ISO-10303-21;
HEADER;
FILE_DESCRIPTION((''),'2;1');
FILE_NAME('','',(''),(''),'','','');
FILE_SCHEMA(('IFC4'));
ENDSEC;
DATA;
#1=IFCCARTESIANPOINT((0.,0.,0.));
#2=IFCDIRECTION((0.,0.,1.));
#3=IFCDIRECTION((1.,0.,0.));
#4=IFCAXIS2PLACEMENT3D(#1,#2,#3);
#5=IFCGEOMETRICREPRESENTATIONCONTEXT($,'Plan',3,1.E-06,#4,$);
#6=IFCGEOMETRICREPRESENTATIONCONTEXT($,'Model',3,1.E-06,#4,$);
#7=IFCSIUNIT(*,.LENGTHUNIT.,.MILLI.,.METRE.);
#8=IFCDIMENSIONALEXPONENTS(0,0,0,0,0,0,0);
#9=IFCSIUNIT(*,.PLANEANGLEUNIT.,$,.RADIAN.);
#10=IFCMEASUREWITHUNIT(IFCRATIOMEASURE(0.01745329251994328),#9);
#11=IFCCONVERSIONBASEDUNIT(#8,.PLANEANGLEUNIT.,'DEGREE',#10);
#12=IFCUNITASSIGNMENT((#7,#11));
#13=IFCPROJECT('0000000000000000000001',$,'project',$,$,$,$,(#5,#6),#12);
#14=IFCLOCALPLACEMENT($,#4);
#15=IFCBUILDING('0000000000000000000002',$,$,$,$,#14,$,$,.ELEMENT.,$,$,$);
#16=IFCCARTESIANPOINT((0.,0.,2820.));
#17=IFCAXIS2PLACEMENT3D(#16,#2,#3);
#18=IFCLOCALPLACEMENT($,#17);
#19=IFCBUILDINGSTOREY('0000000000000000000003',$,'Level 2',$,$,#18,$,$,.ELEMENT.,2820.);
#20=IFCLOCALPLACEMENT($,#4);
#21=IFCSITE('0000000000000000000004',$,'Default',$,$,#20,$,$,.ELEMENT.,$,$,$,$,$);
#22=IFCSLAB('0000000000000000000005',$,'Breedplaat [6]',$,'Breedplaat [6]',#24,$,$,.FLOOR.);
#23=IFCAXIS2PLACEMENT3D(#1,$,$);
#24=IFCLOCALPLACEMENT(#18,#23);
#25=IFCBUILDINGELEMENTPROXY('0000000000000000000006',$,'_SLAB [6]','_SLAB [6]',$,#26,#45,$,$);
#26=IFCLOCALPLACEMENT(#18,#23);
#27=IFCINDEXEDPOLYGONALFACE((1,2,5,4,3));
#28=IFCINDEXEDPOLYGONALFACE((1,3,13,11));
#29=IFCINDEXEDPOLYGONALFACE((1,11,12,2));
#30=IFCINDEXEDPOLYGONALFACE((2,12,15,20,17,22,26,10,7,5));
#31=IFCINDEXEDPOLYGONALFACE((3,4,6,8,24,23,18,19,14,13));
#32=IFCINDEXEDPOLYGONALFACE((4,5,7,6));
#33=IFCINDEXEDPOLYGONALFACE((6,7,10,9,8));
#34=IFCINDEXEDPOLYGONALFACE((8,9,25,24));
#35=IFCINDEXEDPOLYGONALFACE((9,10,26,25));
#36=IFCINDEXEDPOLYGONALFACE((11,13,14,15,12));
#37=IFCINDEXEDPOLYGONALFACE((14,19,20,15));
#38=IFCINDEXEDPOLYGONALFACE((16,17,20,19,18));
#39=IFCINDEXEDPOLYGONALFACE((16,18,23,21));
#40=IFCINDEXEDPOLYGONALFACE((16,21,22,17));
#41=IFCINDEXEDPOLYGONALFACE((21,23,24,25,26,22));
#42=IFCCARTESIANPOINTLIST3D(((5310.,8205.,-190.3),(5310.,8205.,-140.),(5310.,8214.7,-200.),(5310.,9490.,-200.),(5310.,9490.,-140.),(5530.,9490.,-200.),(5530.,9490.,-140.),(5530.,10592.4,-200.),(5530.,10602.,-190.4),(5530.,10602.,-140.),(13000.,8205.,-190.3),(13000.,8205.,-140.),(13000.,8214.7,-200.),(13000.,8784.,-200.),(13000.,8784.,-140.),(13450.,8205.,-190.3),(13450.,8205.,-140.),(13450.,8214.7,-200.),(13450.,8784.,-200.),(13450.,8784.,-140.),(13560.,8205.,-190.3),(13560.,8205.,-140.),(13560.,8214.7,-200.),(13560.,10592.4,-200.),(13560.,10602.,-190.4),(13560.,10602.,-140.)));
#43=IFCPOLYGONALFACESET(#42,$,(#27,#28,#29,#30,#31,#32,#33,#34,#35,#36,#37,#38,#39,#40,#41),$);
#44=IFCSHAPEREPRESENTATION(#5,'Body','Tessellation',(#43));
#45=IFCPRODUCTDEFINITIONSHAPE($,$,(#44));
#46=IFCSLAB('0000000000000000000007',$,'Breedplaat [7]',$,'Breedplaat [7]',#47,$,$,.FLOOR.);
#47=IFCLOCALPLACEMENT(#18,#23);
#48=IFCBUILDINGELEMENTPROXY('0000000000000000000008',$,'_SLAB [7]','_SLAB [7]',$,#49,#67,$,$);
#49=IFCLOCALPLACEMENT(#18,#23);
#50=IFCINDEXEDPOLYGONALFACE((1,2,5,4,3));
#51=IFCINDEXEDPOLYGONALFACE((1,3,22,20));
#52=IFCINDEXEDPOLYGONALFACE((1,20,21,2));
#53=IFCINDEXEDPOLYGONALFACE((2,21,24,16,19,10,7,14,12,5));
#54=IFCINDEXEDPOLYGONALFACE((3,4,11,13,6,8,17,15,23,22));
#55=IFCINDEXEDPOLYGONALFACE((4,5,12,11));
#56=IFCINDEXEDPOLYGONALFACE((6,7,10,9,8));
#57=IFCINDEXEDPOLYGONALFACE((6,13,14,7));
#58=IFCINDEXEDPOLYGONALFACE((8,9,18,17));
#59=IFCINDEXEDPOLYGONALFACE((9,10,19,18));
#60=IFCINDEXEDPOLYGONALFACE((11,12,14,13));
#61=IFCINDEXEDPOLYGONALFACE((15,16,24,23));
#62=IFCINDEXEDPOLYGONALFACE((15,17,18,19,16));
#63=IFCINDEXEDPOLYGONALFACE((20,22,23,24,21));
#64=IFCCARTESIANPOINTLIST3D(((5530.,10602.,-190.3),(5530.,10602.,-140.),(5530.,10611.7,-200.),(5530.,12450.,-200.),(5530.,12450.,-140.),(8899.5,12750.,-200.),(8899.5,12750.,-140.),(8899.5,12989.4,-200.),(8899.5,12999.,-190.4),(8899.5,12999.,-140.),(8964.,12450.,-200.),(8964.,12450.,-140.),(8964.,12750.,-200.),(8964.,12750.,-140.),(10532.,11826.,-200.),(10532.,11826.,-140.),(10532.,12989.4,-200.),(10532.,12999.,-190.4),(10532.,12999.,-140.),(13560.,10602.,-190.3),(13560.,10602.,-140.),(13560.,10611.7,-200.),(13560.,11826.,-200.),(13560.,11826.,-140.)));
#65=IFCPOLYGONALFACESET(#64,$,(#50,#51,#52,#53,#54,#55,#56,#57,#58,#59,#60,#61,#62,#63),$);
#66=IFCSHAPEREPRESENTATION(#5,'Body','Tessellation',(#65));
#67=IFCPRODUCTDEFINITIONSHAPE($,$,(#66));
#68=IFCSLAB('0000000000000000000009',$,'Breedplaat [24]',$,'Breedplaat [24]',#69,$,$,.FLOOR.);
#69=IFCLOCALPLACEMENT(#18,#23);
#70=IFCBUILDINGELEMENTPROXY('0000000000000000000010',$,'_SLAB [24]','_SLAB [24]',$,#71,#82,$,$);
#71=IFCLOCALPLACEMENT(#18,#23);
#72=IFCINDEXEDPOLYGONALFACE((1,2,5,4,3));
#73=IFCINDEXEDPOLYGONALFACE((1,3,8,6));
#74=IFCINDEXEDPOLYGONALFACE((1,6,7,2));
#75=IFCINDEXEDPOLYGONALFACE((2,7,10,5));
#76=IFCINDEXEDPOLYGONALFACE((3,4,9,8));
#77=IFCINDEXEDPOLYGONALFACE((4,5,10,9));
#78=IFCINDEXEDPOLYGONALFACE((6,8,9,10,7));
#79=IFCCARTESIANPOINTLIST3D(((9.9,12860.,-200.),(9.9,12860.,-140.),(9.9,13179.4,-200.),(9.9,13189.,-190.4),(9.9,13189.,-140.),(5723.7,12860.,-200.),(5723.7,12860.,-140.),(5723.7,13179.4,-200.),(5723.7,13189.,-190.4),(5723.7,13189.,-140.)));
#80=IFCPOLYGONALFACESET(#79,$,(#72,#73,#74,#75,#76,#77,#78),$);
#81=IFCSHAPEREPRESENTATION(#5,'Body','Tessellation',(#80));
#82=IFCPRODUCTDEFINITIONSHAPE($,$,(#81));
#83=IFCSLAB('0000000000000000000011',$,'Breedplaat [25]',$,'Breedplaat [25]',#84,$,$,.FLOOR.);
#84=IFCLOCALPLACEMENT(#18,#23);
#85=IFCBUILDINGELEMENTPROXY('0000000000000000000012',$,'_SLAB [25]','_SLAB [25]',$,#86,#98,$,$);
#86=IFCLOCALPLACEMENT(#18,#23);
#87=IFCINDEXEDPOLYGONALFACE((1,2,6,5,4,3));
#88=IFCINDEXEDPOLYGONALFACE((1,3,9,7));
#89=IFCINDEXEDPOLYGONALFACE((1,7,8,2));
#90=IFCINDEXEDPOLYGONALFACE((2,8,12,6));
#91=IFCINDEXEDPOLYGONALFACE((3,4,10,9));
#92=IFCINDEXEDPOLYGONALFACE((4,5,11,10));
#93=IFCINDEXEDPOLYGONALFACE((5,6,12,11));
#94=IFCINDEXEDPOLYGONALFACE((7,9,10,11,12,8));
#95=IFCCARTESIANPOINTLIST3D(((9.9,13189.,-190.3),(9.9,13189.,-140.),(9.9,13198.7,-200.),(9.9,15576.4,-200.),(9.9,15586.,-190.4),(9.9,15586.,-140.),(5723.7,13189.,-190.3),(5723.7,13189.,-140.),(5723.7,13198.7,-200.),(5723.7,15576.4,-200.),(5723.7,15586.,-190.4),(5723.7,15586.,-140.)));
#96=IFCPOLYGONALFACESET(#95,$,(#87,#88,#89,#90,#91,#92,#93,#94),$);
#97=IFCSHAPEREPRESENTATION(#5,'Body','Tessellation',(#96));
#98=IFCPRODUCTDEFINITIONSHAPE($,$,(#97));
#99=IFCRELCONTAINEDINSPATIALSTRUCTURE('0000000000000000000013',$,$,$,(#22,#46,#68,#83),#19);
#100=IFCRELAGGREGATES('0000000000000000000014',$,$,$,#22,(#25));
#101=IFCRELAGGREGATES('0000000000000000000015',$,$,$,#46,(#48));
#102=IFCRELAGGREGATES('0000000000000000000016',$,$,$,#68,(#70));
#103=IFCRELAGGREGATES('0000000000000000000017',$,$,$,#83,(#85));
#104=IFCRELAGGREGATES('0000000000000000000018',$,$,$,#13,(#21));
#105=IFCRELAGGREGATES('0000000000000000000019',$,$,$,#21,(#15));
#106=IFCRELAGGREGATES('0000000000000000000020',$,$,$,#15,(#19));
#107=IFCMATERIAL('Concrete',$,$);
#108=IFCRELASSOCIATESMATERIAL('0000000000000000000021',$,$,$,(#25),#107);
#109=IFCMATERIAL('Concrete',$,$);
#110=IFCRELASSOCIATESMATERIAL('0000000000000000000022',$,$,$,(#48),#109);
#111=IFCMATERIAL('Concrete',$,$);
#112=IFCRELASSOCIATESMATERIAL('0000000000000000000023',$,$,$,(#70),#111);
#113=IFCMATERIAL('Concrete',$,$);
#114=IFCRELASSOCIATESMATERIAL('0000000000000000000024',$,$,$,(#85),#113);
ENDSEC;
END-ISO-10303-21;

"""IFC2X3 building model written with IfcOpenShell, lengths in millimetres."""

from ifc_helpers import new_model, entity, si_unit, converted_unit, frame, origin_with_axes, origin_2d_with_axis, place, context, project, spatial, polyline, rectangle, outline, extrude, material, element, aggregate, save


model = new_model("IFC2X3")

# Units and contexts
plan_context = context("Plan", 3, precision=1e-06, world=origin_with_axes())
model_context = context("Model", 3, precision=1e-06, world=origin_with_axes())
ifc_project = project(units=[si_unit("LENGTHUNIT", "METRE", prefix="MILLI"), converted_unit("PLANEANGLEUNIT", "DEGREE", entity("IfcRatioMeasure", 0.01745329251994328), si_unit("PLANEANGLEUNIT", "RADIAN"), dimensions=[0, 0, 0, 0, 0, 0, 0])], contexts=[plan_context, model_context])

# Site, building, storey
site_placement = place(None, origin_with_axes())
site = spatial("IfcSite", under=ifc_project, at=site_placement, Name="Default", CompositionType="ELEMENT")
building_placement = place(None, origin_with_axes())
building = spatial("IfcBuilding", under=site, at=building_placement, CompositionType="ELEMENT")
storey_placement = place(None, frame((0.0, 0.0, 2820.0), z_axis=(0.0, 0.0, 1.0), x_axis=(1.0, 0.0, 0.0)))
storey = spatial("IfcBuildingStorey", under=building, at=storey_placement, Name="Level 2", CompositionType="ELEMENT", Elevation=2820.0)

# Slabs, building element proxies, openings
slab_1_placement = place(None, frame((5310.0, 8205.0, 2620.0), z_axis=(0.0, 0.0, 1.0), x_axis=(1.0, 0.0, 0.0)))
slab_1 = element("IfcSlab", 1, at=slab_1_placement, inside=storey, Name="Breedplaat [6]", ObjectType="Breedplaat [6]", PredefinedType="FLOOR")
ifc_material_1 = material(Name="Concrete")
proxy_1_placement = place(slab_1_placement, origin_with_axes())
proxy_1 = element("IfcBuildingElementProxy", 2, at=proxy_1_placement, material=ifc_material_1, Name="_SLAB [6]", Description="_SLAB [6]", context=plan_context, shape_type="SweptSolid", body=[
    extrude(outline(polyline([(220.0, 2397.0), (220.0, 1285.0), (0.0, 1285.0), (0.0, 0.0), (8250.0, 0.0), (8250.0, 2397.0), (220.0, 2397.0)])), origin_with_axes(), (0.0, 0.0, 1.0), 60.0),
])
opening_1_placement = place(slab_1_placement, frame((7690.0, 0.0, 0.0), z_axis=(0.0, 0.0, 1.0), x_axis=(1.0, 0.0, 0.0)))
element("IfcOpeningElement", 3, at=opening_1_placement, cuts=proxy_1, ObjectType="Opening", context=plan_context, shape_type="SolidModel", body=[
    extrude(rectangle(XDim=450.0, YDim=579.0, at=origin_2d_with_axis()), frame((225.0, 289.5, 0.0), z_axis=(0.0, 0.0, 1.0), x_axis=(1.0, 0.0, 0.0)), (0.0, 0.0, 1.0), 60.0),
])
opening_2_placement = place(None, frame((5310.0, 8205.0, 2620.0), z_axis=(0.0, 0.0, 1.0), x_axis=(1.0, 0.0, 0.0)))
element("IfcOpeningElement", 4, at=opening_2_placement, cuts=proxy_1, ObjectType="Opening", context=plan_context, shape_type="SweptSolid", body=[
    extrude(outline(polyline([(-0.1, -0.1), (-0.1, 10.0), (10.0, -0.1), (-0.1, -0.1)])), frame((-1.2, -0.1, -0.1), z_axis=(1.0, 0.0, 0.0), x_axis=(0.0, 1.0, 0.0)), (0.0, 0.0, 1.0), 8252.2),
])
opening_3_placement = place(None, frame((5310.0, 8205.0, 2620.0), z_axis=(0.0, 0.0, 1.0), x_axis=(1.0, 0.0, 0.0)))
element("IfcOpeningElement", 5, at=opening_3_placement, cuts=proxy_1, ObjectType="Opening", context=plan_context, shape_type="SweptSolid", body=[
    extrude(outline(polyline([(-0.1, -0.1), (-0.1, 10.0), (10.0, -0.1), (-0.1, -0.1)])), frame((8251.2, 2397.2, -0.1), z_axis=(-1.0, 0.0, 0.0), x_axis=(0.0, -1.0, 0.0)), (0.0, 0.0, 1.0), 8032.2),
])
aggregate(slab_1, [proxy_1])
slab_2_placement = place(None, frame((5530.0, 10602.0, 2620.0), z_axis=(0.0, 0.0, 1.0), x_axis=(1.0, 0.0, 0.0)))
slab_2 = element("IfcSlab", 6, at=slab_2_placement, inside=storey, Name="Breedplaat [7]", ObjectType="Breedplaat [7]", PredefinedType="FLOOR")
ifc_material_2 = material(Name="Concrete")
proxy_2_placement = place(slab_2_placement, origin_with_axes())
proxy_2 = element("IfcBuildingElementProxy", 7, at=proxy_2_placement, material=ifc_material_2, Name="_SLAB [7]", Description="_SLAB [7]", context=plan_context, shape_type="SweptSolid", body=[
    extrude(outline(polyline([(3434.0, 2148.0), (3434.0, 1848.0), (0.0, 1848.0), (0.0, 0.0), (8030.0, 0.0), (8030.0, 1224.0), (5002.0, 1224.0), (5002.0, 2397.0), (3369.5, 2397.0), (3369.5, 2148.0), (3434.0, 2148.0)])), origin_with_axes(), (0.0, 0.0, 1.0), 60.0),
])
opening_4_placement = place(None, frame((5530.0, 10602.0, 2620.0), z_axis=(0.0, 0.0, 1.0), x_axis=(1.0, 0.0, 0.0)))
element("IfcOpeningElement", 8, at=opening_4_placement, cuts=proxy_2, ObjectType="Opening", context=plan_context, shape_type="SweptSolid", body=[
    extrude(outline(polyline([(-0.1, -0.1), (-0.1, 10.0), (10.0, -0.1), (-0.1, -0.1)])), frame((-1.2, -0.1, -0.1), z_axis=(1.0, 0.0, 0.0), x_axis=(0.0, 1.0, 0.0)), (0.0, 0.0, 1.0), 8032.2),
])
opening_5_placement = place(None, frame((5530.0, 10602.0, 2620.0), z_axis=(0.0, 0.0, 1.0), x_axis=(1.0, 0.0, 0.0)))
element("IfcOpeningElement", 9, at=opening_5_placement, cuts=proxy_2, ObjectType="Opening", context=plan_context, shape_type="SweptSolid", body=[
    extrude(outline(polyline([(-0.1, -0.1), (-0.1, 10.0), (10.0, -0.1), (-0.1, -0.1)])), frame((5003.2, 2397.2, -0.1), z_axis=(-1.0, 0.0, 0.0), x_axis=(0.0, -1.0, 0.0)), (0.0, 0.0, 1.0), 1634.7),
])
aggregate(slab_2, [proxy_2])

# Slab, building element proxy, opening
slab_3_placement = place(None, frame((9.9, 12860.0, 2620.0), z_axis=(0.0, 0.0, 1.0), x_axis=(1.0, 0.0, 0.0)))
slab_3 = element("IfcSlab", 10, at=slab_3_placement, inside=storey, Name="Breedplaat [24]", ObjectType="Breedplaat [24]", PredefinedType="FLOOR")
ifc_material_3 = material(Name="Concrete")
proxy_3_placement = place(slab_3_placement, origin_with_axes())
proxy_3 = element("IfcBuildingElementProxy", 11, at=proxy_3_placement, material=ifc_material_3, Name="_SLAB [24]", Description="_SLAB [24]", context=plan_context, shape_type="SweptSolid", body=[
    extrude(outline(polyline([(5713.8, 0.0), (5713.8, 329.0), (0.0, 329.0), (0.0, 0.0), (5713.8, 0.0)])), origin_with_axes(), (0.0, 0.0, 1.0), 60.0),
])
opening_6_placement = place(None, frame((9.9, 12860.0, 2620.0), z_axis=(0.0, 0.0, 1.0), x_axis=(1.0, 0.0, 0.0)))
element("IfcOpeningElement", 12, at=opening_6_placement, cuts=proxy_3, ObjectType="Opening", context=plan_context, shape_type="SweptSolid", body=[
    extrude(outline(polyline([(-0.1, -0.1), (-0.1, 10.0), (10.0, -0.1), (-0.1, -0.1)])), frame((5715.0, 329.2, -0.1), z_axis=(-1.0, 0.0, 0.0), x_axis=(0.0, -1.0, 0.0)), (0.0, 0.0, 1.0), 5716.0),
])
aggregate(slab_3, [proxy_3])

# Slab, building element proxy, openings
slab_4_placement = place(None, frame((9.9, 13189.0, 2620.0), z_axis=(0.0, 0.0, 1.0), x_axis=(1.0, 0.0, 0.0)))
slab_4 = element("IfcSlab", 13, at=slab_4_placement, inside=storey, Name="Breedplaat [25]", ObjectType="Breedplaat [25]", PredefinedType="FLOOR")
ifc_material_4 = material(Name="Concrete")
proxy_4_placement = place(slab_4_placement, origin_with_axes())
proxy_4 = element("IfcBuildingElementProxy", 14, at=proxy_4_placement, material=ifc_material_4, Name="_SLAB [25]", Description="_SLAB [25]", context=plan_context, shape_type="SweptSolid", body=[
    extrude(outline(polyline([(5713.8, 0.0), (5713.8, 2397.0), (0.0, 2397.0), (0.0, 0.0), (5713.8, 0.0)])), origin_with_axes(), (0.0, 0.0, 1.0), 60.0),
])
opening_7_placement = place(None, frame((9.9, 13189.0, 2620.0), z_axis=(0.0, 0.0, 1.0), x_axis=(1.0, 0.0, 0.0)))
element("IfcOpeningElement", 15, at=opening_7_placement, cuts=proxy_4, ObjectType="Opening", context=plan_context, shape_type="SweptSolid", body=[
    extrude(outline(polyline([(-0.1, -0.1), (-0.1, 10.0), (10.0, -0.1), (-0.1, -0.1)])), frame((-1.2, -0.1, -0.1), z_axis=(1.0, 0.0, 0.0), x_axis=(0.0, 1.0, 0.0)), (0.0, 0.0, 1.0), 5716.0),
])
opening_8_placement = place(None, frame((9.9, 13189.0, 2620.0), z_axis=(0.0, 0.0, 1.0), x_axis=(1.0, 0.0, 0.0)))
element("IfcOpeningElement", 16, at=opening_8_placement, cuts=proxy_4, ObjectType="Opening", context=plan_context, shape_type="SweptSolid", body=[
    extrude(outline(polyline([(-0.1, -0.1), (-0.1, 10.0), (10.0, -0.1), (-0.1, -0.1)])), frame((5715.0, 2397.2, -0.1), z_axis=(-1.0, 0.0, 0.0), x_axis=(0.0, -1.0, 0.0)), (0.0, 0.0, 1.0), 5716.0),
])
aggregate(slab_4, [proxy_4])

save(model, "model.ifc")
